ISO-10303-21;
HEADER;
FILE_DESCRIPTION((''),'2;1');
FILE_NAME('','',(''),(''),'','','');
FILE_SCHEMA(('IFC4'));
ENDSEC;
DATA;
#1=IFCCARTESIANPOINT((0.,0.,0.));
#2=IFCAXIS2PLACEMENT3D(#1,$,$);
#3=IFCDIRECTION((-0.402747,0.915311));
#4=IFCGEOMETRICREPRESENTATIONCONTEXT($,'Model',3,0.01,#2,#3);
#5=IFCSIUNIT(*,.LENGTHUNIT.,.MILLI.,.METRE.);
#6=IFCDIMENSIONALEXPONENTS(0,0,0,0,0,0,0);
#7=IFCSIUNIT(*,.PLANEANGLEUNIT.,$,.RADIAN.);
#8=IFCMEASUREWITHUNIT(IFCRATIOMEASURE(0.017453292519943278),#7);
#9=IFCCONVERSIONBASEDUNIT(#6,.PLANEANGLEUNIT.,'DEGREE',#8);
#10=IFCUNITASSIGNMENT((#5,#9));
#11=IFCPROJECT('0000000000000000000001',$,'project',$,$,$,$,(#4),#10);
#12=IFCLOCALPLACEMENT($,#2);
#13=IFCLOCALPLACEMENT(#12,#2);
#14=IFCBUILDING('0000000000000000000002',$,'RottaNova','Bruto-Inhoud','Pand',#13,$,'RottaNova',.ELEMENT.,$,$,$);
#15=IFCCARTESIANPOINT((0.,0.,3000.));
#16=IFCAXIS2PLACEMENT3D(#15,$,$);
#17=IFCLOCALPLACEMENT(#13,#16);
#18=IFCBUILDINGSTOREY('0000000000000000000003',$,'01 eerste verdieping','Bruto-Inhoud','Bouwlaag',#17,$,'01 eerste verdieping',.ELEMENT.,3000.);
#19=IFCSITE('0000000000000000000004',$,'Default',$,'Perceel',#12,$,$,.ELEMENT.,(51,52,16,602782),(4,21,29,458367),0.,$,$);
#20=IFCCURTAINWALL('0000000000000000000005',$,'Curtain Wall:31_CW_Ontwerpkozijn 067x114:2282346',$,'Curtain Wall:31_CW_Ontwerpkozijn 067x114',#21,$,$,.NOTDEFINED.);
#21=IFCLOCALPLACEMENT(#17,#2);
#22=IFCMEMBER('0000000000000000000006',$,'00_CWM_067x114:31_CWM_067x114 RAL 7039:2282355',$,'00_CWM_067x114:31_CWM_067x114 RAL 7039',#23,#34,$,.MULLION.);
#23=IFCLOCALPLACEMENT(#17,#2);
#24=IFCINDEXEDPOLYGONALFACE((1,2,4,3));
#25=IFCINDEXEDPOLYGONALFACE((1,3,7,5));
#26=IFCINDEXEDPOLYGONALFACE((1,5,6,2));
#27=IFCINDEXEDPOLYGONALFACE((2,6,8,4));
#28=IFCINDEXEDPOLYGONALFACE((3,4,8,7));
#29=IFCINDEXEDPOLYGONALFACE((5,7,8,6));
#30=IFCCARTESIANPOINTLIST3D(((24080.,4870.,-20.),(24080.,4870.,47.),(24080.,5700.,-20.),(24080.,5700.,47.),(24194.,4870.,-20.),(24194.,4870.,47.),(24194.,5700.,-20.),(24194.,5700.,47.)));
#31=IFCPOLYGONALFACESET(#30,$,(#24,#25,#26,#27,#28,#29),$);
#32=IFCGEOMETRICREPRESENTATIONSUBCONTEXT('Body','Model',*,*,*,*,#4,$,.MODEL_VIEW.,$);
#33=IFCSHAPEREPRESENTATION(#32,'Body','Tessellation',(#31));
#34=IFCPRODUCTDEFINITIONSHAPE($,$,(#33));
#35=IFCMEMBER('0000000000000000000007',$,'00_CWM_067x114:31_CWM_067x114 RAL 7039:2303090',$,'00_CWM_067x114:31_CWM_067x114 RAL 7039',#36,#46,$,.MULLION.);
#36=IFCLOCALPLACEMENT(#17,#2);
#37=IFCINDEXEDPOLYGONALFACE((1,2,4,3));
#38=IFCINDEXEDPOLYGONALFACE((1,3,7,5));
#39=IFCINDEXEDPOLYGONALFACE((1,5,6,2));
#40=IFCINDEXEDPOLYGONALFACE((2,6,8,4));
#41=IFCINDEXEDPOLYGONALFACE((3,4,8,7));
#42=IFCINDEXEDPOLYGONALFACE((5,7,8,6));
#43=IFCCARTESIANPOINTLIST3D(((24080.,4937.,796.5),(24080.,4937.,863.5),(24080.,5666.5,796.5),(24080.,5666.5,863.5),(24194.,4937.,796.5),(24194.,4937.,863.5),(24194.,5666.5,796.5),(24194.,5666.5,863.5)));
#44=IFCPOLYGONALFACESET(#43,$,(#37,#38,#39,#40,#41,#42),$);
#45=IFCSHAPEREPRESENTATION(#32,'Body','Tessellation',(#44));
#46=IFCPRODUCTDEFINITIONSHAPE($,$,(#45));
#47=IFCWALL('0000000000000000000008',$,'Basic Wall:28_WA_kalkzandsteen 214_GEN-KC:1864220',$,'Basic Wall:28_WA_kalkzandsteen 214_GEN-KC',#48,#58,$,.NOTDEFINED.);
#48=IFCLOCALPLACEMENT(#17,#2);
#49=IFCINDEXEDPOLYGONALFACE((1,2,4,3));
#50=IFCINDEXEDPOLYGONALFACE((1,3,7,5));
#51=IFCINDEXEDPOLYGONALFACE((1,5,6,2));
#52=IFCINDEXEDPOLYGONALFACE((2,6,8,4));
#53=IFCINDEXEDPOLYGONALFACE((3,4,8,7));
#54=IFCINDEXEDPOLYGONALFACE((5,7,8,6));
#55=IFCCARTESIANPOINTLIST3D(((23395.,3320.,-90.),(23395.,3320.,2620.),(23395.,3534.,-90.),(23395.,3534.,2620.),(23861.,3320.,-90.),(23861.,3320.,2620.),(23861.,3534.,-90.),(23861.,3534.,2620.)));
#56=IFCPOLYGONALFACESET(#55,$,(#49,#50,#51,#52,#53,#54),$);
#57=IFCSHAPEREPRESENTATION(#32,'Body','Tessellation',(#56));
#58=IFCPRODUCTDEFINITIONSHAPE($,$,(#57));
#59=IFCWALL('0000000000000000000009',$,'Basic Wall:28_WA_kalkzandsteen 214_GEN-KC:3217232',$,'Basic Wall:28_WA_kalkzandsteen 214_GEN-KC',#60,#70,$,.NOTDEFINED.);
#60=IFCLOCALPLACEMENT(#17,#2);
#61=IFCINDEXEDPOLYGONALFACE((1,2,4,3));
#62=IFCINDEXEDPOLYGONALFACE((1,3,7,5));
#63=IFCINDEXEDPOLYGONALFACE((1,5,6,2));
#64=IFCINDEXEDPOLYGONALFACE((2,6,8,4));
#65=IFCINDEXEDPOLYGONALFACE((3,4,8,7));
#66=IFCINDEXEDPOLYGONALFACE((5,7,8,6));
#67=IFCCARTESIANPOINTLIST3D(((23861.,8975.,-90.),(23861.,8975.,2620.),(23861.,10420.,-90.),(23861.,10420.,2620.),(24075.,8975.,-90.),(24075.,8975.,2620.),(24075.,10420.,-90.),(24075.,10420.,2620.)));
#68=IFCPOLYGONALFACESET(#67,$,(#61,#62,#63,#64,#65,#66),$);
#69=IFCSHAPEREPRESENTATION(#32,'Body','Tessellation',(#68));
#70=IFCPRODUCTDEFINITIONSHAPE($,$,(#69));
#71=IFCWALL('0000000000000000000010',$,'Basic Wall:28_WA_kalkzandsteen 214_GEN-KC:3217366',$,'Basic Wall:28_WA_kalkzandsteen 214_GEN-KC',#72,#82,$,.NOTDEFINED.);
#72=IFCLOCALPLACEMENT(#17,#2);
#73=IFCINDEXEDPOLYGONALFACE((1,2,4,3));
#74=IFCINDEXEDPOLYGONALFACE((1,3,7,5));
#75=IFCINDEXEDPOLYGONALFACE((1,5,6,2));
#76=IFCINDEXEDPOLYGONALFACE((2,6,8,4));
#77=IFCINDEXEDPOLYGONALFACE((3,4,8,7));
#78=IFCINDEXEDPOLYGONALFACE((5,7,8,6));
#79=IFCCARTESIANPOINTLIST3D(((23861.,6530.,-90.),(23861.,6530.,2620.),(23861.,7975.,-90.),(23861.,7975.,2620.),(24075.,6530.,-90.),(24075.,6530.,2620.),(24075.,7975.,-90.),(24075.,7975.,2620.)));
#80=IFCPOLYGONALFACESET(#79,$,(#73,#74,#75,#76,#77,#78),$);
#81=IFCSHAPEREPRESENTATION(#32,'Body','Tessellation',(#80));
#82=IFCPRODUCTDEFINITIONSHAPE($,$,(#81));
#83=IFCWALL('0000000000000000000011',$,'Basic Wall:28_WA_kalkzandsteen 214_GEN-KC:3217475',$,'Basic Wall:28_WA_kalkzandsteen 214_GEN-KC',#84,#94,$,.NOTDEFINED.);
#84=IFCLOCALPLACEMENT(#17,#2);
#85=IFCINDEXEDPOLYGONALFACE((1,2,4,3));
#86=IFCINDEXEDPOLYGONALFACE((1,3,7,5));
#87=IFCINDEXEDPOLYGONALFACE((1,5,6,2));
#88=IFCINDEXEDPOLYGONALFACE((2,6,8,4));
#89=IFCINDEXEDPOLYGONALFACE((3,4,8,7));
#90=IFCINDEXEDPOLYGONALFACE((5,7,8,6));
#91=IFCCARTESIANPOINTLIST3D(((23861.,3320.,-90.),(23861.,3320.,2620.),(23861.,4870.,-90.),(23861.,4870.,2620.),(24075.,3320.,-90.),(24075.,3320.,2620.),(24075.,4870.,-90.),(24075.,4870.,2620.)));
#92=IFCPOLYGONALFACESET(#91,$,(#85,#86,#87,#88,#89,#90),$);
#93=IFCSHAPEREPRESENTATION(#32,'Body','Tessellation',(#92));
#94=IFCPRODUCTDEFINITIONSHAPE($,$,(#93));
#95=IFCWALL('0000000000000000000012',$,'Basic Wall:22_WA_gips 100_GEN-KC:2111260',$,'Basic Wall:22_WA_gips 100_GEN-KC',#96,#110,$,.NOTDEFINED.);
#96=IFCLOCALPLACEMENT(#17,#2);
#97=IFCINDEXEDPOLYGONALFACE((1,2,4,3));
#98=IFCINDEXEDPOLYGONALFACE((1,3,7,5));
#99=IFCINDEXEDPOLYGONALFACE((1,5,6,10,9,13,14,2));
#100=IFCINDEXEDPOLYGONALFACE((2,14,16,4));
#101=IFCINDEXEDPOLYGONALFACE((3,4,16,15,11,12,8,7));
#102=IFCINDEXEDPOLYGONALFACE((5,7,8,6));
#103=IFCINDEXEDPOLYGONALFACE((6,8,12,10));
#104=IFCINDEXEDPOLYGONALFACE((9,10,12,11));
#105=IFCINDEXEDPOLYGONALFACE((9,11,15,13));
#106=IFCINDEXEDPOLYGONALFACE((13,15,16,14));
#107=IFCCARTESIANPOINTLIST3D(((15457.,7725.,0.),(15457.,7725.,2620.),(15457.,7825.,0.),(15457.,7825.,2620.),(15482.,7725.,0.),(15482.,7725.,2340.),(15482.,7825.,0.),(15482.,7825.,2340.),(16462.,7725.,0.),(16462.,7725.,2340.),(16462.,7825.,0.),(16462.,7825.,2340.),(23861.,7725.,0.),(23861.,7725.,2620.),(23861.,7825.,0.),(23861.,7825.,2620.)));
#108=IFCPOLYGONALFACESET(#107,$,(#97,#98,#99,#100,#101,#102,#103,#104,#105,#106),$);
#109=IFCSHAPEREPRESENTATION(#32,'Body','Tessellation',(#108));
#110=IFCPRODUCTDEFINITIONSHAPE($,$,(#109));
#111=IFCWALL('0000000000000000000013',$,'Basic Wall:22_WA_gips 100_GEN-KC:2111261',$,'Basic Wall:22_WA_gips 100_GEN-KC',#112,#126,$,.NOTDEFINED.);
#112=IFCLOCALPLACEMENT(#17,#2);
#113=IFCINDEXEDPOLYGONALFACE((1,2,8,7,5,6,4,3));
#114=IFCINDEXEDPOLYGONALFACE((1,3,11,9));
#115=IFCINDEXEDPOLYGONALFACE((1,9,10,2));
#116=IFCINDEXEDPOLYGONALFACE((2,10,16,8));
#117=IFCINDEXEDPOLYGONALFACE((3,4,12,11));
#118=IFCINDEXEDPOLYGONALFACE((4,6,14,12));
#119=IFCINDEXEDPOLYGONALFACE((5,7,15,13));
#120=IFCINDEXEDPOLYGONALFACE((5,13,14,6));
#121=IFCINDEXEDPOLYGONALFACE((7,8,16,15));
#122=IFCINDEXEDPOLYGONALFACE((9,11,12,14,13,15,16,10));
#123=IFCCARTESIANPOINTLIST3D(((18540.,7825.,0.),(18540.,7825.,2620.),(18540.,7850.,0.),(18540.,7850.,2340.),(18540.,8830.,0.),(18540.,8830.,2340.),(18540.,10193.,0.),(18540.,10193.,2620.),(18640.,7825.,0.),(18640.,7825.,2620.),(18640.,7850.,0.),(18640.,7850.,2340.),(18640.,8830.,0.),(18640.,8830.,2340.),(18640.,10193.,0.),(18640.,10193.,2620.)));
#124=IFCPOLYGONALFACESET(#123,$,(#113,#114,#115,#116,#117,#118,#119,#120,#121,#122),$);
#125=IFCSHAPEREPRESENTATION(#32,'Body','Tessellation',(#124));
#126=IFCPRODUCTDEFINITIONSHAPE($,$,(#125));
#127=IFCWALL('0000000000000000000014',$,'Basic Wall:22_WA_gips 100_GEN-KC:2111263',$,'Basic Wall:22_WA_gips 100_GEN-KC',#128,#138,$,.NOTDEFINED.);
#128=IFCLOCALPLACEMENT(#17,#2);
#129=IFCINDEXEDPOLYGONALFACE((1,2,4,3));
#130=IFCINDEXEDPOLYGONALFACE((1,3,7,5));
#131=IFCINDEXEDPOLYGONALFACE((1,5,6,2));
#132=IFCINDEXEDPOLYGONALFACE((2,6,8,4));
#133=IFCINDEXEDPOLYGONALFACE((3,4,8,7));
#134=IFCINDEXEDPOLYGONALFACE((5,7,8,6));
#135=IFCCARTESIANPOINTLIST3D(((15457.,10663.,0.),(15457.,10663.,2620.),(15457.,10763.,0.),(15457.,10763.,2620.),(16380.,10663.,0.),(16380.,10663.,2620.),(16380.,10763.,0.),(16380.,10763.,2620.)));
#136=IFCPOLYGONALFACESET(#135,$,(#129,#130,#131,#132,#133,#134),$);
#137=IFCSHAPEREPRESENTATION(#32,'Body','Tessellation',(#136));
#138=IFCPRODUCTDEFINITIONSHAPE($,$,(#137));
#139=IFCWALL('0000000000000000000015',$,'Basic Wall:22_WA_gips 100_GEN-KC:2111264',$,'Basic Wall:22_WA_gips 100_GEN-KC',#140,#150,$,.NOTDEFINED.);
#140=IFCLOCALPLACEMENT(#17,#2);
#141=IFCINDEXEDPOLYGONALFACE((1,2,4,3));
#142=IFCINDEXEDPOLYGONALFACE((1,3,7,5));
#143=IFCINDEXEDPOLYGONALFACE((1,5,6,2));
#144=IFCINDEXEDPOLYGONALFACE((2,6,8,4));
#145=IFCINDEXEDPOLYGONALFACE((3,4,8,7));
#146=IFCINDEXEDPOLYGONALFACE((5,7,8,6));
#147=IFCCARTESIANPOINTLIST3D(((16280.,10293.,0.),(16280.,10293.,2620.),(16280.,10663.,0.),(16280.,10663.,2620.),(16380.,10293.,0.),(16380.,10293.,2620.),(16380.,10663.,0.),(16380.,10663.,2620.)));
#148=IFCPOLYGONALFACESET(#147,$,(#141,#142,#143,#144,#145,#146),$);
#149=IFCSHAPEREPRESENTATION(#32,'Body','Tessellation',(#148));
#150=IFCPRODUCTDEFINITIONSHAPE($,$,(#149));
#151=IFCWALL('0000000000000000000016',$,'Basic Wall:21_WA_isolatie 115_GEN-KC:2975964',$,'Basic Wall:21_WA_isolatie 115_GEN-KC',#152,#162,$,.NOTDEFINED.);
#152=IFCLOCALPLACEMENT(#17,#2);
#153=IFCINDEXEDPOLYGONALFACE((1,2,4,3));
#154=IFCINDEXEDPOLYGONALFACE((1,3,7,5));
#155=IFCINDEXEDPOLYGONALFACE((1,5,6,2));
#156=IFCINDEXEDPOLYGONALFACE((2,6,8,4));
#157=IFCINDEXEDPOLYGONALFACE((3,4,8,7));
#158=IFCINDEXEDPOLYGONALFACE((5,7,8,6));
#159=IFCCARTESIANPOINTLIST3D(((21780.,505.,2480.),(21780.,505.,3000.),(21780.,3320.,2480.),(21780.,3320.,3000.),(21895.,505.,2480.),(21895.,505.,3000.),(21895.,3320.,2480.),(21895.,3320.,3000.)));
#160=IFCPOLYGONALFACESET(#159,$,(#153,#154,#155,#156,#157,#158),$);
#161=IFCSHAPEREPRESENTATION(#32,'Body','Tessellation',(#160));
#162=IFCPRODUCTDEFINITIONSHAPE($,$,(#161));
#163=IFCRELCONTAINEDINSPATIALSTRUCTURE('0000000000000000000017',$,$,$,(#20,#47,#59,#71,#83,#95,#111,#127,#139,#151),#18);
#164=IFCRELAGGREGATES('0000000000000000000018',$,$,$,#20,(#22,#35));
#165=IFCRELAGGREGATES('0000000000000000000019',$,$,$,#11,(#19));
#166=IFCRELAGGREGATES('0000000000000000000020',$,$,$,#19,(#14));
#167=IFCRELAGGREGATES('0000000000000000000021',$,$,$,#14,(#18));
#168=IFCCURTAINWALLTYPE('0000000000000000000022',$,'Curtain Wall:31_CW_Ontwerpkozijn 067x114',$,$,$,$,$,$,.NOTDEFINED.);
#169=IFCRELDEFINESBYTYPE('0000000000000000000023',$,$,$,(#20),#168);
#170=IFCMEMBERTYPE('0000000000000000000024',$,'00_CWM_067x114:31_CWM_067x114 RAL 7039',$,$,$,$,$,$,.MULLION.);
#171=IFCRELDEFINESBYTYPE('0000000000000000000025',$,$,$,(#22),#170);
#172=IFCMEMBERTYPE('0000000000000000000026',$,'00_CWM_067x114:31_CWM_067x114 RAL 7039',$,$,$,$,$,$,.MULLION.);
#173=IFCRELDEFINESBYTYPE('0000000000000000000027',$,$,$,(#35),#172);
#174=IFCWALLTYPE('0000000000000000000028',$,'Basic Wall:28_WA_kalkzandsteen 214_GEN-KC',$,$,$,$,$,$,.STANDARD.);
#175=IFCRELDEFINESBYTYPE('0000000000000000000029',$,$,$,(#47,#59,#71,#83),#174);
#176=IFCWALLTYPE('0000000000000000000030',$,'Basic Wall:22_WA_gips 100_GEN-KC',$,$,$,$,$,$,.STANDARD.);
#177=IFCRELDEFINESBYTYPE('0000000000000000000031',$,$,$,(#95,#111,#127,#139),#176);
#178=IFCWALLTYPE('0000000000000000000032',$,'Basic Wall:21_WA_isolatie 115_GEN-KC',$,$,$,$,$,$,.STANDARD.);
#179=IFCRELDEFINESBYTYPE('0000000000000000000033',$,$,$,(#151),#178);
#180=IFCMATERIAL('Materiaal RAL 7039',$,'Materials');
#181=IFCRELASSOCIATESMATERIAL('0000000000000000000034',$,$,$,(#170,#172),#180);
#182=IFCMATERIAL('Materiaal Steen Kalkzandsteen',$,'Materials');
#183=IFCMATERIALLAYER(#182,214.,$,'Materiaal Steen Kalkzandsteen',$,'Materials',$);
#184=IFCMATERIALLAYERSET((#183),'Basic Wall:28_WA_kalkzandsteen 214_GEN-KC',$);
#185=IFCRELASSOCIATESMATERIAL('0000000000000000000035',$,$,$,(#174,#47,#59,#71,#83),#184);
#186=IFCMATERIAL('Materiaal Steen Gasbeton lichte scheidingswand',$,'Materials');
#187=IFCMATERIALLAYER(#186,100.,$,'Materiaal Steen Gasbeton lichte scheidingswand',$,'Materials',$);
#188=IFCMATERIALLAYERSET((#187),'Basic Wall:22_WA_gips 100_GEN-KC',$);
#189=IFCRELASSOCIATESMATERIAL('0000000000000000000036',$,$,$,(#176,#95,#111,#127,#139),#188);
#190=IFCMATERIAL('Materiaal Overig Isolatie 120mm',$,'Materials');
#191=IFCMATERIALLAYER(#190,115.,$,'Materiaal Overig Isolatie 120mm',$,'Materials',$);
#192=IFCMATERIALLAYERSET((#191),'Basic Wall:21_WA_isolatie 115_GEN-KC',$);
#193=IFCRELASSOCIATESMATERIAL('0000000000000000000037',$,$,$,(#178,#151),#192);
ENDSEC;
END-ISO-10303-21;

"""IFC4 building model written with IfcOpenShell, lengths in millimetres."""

from ifc_helpers import new_model, entity, si_unit, converted_unit, direction, frame, frame_2d, origin, origin_2d_with_axis, place, context, subcontext, project, spatial, rectangle, extrude, source, transform, mapped, material, layer, layer_set, material_profile, profile_set, type_object, type_shapes, element, aggregate, save


model = new_model("IFC4")

# Units and contexts
model_context = context("Model", 3, precision=0.01, world=origin(), true_north=direction((-0.402747, 0.915311)))
body_context = subcontext(model_context, "Body", "Model", "MODEL_VIEW")
ifc_project = project(units=[si_unit("LENGTHUNIT", "METRE", prefix="MILLI"), converted_unit("PLANEANGLEUNIT", "DEGREE", entity("IfcRatioMeasure", 0.017453292519943278), si_unit("PLANEANGLEUNIT", "RADIAN"), dimensions=[0, 0, 0, 0, 0, 0, 0])], contexts=[model_context])

# Site, building, storey
site_placement = place(None, origin())
site = spatial("IfcSite", under=ifc_project, at=site_placement, Name="Default", ObjectType="Perceel", CompositionType="ELEMENT", RefLatitude=(51, 52, 16, 602782), RefLongitude=(4, 21, 29, 458367), RefElevation=0.0)
building_placement = place(site_placement, origin())
building = spatial("IfcBuilding", under=site, at=building_placement, Name="RottaNova", Description="Bruto-Inhoud", ObjectType="Pand", LongName="RottaNova", CompositionType="ELEMENT")
storey_placement = place(building_placement, frame((0.0, 0.0, 3000.0)))
storey = spatial("IfcBuildingStorey", under=building, at=storey_placement, Name="01 eerste verdieping", Description="Bruto-Inhoud", ObjectType="Bouwlaag", LongName="01 eerste verdieping", CompositionType="ELEMENT", Elevation=3000.0)

# Curtain wall, members
curtain_wall_type = type_object("IfcCurtainWallType", Name="Curtain Wall:31_CW_Ontwerpkozijn 067x114", PredefinedType="NOTDEFINED")
ifc_material_1 = material(Name="Materiaal RAL 7039", Category="Materials")
ifc_material_profile = material_profile(ifc_material_1, rectangle(XDim=114.0, YDim=67.0, at=origin_2d_with_axis()), Name="31_CWM_067x114 RAL 7039")
ifc_profile_set = profile_set([ifc_material_profile], Name="31_CWM_067x114 RAL 7039")
curtain_wall_1_placement = place(storey_placement, frame((0.0, 0.0, -3000.0)))
curtain_wall_1 = element("IfcCurtainWall", 1, at=curtain_wall_1_placement, inside=storey, type_object=curtain_wall_type, Name="Curtain Wall:31_CW_Ontwerpkozijn 067x114:2282346", ObjectType="Curtain Wall:31_CW_Ontwerpkozijn 067x114", PredefinedType="NOTDEFINED")
member_type_1 = type_object("IfcMemberType", Name="00_CWM_067x114:31_CWM_067x114 RAL 7039", PredefinedType="MULLION", material=ifc_profile_set)
shared_shape_1 = source(origin(), body_context, "Body", "SweptSolid", [
    extrude(rectangle(XDim=114.0, YDim=67.0, at=frame_2d((0.0, 0.0), x_axis=(1.0, 0.0))), frame((-33.5, -57.0, -830.0), z_axis=(0.0, 0.0, 1.0), x_axis=(0.0, -1.0, 0.0)), (0.0, 0.0, 1.0), 830.0),
])
type_shapes(member_type_1, [shared_shape_1])
member_1_placement = place(curtain_wall_1_placement, frame((24080.0, 5700.0, 2980.0), z_axis=(0.0, 1.0, 0.0), x_axis=(0.0, 0.0, -1.0)))
member_1 = element("IfcMember", 2, at=member_1_placement, type_object=member_type_1, Name="00_CWM_067x114:31_CWM_067x114 RAL 7039:2282355", ObjectType="00_CWM_067x114:31_CWM_067x114 RAL 7039", PredefinedType="MULLION", context=body_context, shape_type="MappedRepresentation", body=[
    mapped(shared_shape_1, transform((0.0, 0.0, 0.0), scale=1.0)),
])
member_type_2 = type_object("IfcMemberType", Name="00_CWM_067x114:31_CWM_067x114 RAL 7039", PredefinedType="MULLION", material=ifc_profile_set)
shared_shape_2 = source(origin(), body_context, "Body", "SweptSolid", [
    extrude(rectangle(XDim=114.0, YDim=67.0, at=origin_2d_with_axis()), frame((0.0, -57.0, -729.5), z_axis=(0.0, 0.0, 1.0), x_axis=(0.0, -1.0, 0.0)), (0.0, 0.0, 1.0), 729.5),
])
type_shapes(member_type_2, [shared_shape_2])
member_2_placement = place(curtain_wall_1_placement, frame((24080.0, 4937.0, 3830.0), z_axis=(0.0, -1.0, 0.0), x_axis=(0.0, 0.0, 1.0)))
member_2 = element("IfcMember", 3, at=member_2_placement, type_object=member_type_2, Name="00_CWM_067x114:31_CWM_067x114 RAL 7039:2303090", ObjectType="00_CWM_067x114:31_CWM_067x114 RAL 7039", PredefinedType="MULLION", context=body_context, shape_type="MappedRepresentation", body=[
    mapped(shared_shape_2, transform((0.0, 0.0, 0.0), scale=1.0)),
])

# Walls
ifc_material_2 = material(Name="Materiaal Steen Kalkzandsteen", Category="Materials")
ifc_layer_1 = layer(ifc_material_2, 214.0, Name="Materiaal Steen Kalkzandsteen", Category="Materials")
ifc_layer_set_1 = layer_set([ifc_layer_1], Name="Basic Wall:28_WA_kalkzandsteen 214_GEN-KC")
wall_type_1 = type_object("IfcWallType", Name="Basic Wall:28_WA_kalkzandsteen 214_GEN-KC", PredefinedType="STANDARD", material=ifc_layer_set_1)
wall_1_placement = place(storey_placement, frame((23861.0, 3427.0, -90.0), z_axis=(0.0, 0.0, 1.0), x_axis=(-1.0, 0.0, 0.0)))
element("IfcWall", 4, at=wall_1_placement, inside=storey, type_object=wall_type_1, material=ifc_layer_set_1, Name="Basic Wall:28_WA_kalkzandsteen 214_GEN-KC:1864220", ObjectType="Basic Wall:28_WA_kalkzandsteen 214_GEN-KC", PredefinedType="NOTDEFINED", context=body_context, shape_type="SweptSolid", body=[
    extrude(rectangle(XDim=466.0, YDim=214.0, at=frame_2d((233.0, 0.0), x_axis=(-1.0, 0.0))), origin(), (0.0, 0.0, 1.0), 2710.0),
])
wall_2_placement = place(storey_placement, frame((23968.0, 10420.0, -90.0), z_axis=(0.0, 0.0, 1.0), x_axis=(0.0, -1.0, 0.0)))
element("IfcWall", 5, at=wall_2_placement, inside=storey, type_object=wall_type_1, material=ifc_layer_set_1, Name="Basic Wall:28_WA_kalkzandsteen 214_GEN-KC:3217232", ObjectType="Basic Wall:28_WA_kalkzandsteen 214_GEN-KC", PredefinedType="NOTDEFINED", context=body_context, shape_type="SweptSolid", body=[
    extrude(rectangle(XDim=1445.0, YDim=214.0, at=frame_2d((722.5, 0.0), x_axis=(-1.0, 0.0))), origin(), (0.0, 0.0, 1.0), 2710.0),
])
wall_3_placement = place(storey_placement, frame((23968.0, 7975.0, -90.0), z_axis=(0.0, 0.0, 1.0), x_axis=(0.0, -1.0, 0.0)))
element("IfcWall", 6, at=wall_3_placement, inside=storey, type_object=wall_type_1, material=ifc_layer_set_1, Name="Basic Wall:28_WA_kalkzandsteen 214_GEN-KC:3217366", ObjectType="Basic Wall:28_WA_kalkzandsteen 214_GEN-KC", PredefinedType="NOTDEFINED", context=body_context, shape_type="SweptSolid", body=[
    extrude(rectangle(XDim=1445.0, YDim=214.0, at=frame_2d((722.5, 0.0), x_axis=(-1.0, 0.0))), origin(), (0.0, 0.0, 1.0), 2710.0),
])
wall_4_placement = place(storey_placement, frame((23968.0, 4870.0, -90.0), z_axis=(0.0, 0.0, 1.0), x_axis=(0.0, -1.0, 0.0)))
element("IfcWall", 7, at=wall_4_placement, inside=storey, type_object=wall_type_1, material=ifc_layer_set_1, Name="Basic Wall:28_WA_kalkzandsteen 214_GEN-KC:3217475", ObjectType="Basic Wall:28_WA_kalkzandsteen 214_GEN-KC", PredefinedType="NOTDEFINED", context=body_context, shape_type="SweptSolid", body=[
    extrude(rectangle(XDim=1550.0, YDim=214.0, at=frame_2d((775.0, 0.0), x_axis=(-1.0, 0.0))), origin(), (0.0, 0.0, 1.0), 2710.0),
])

# Walls, openings
ifc_material_3 = material(Name="Materiaal Steen Gasbeton lichte scheidingswand", Category="Materials")
ifc_layer_2 = layer(ifc_material_3, 100.0, Name="Materiaal Steen Gasbeton lichte scheidingswand", Category="Materials")
ifc_layer_set_2 = layer_set([ifc_layer_2], Name="Basic Wall:22_WA_gips 100_GEN-KC")
wall_type_2 = type_object("IfcWallType", Name="Basic Wall:22_WA_gips 100_GEN-KC", PredefinedType="STANDARD", material=ifc_layer_set_2)
wall_5_placement = place(storey_placement, frame((23861.0, 7775.0, 0.0), z_axis=(0.0, 0.0, 1.0), x_axis=(-1.0, 0.0, 0.0)))
wall_5 = element("IfcWall", 8, at=wall_5_placement, inside=storey, type_object=wall_type_2, material=ifc_layer_set_2, Name="Basic Wall:22_WA_gips 100_GEN-KC:2111260", ObjectType="Basic Wall:22_WA_gips 100_GEN-KC", PredefinedType="NOTDEFINED", context=body_context, shape_type="SweptSolid", body=[
    extrude(rectangle(XDim=8404.0, YDim=100.0, at=frame_2d((4202.0, 0.0), x_axis=(1.0, 0.0))), origin(), (0.0, 0.0, 1.0), 2620.0),
])
opening_1_placement = place(wall_5_placement, frame((7399.0, -50.0, -90.0)))
element("IfcOpeningElement", 9, at=opening_1_placement, cuts=wall_5, PredefinedType="OPENING", context=body_context, shape_type="SweptSolid", body=[
    extrude(rectangle(XDim=2430.0, YDim=980.0, at=frame_2d((1215.0, 490.0), x_axis=(1.0, 0.0))), frame((0.0, 0.0, 0.0), z_axis=(0.0, 1.0, 0.0), x_axis=(0.0, 0.0, 1.0)), (0.0, 0.0, 1.0), 100.0),
])
wall_6_placement = place(storey_placement, frame((18590.0, 10193.0, 0.0), z_axis=(0.0, 0.0, 1.0), x_axis=(0.0, -1.0, 0.0)))
wall_6 = element("IfcWall", 10, at=wall_6_placement, inside=storey, type_object=wall_type_2, material=ifc_layer_set_2, Name="Basic Wall:22_WA_gips 100_GEN-KC:2111261", ObjectType="Basic Wall:22_WA_gips 100_GEN-KC", PredefinedType="NOTDEFINED", context=body_context, shape_type="SweptSolid", body=[
    extrude(rectangle(XDim=2368.0, YDim=100.0, at=frame_2d((1184.0, 0.0), x_axis=(1.0, 0.0))), origin(), (0.0, 0.0, 1.0), 2620.0),
])
opening_2_placement = place(wall_6_placement, frame((1363.0, -50.0, -90.0)))
element("IfcOpeningElement", 11, at=opening_2_placement, cuts=wall_6, PredefinedType="OPENING", context=body_context, shape_type="SweptSolid", body=[
    extrude(rectangle(XDim=2430.0, YDim=980.0, at=frame_2d((1215.0, 490.0), x_axis=(1.0, 0.0))), frame((0.0, 0.0, 0.0), z_axis=(0.0, 1.0, 0.0), x_axis=(0.0, 0.0, 1.0)), (0.0, 0.0, 1.0), 100.0),
])

# Walls
wall_7_placement = place(storey_placement, frame((16380.0, 10713.0, 0.0), z_axis=(0.0, 0.0, 1.0), x_axis=(-1.0, 0.0, 0.0)))
element("IfcWall", 12, at=wall_7_placement, inside=storey, type_object=wall_type_2, material=ifc_layer_set_2, Name="Basic Wall:22_WA_gips 100_GEN-KC:2111263", ObjectType="Basic Wall:22_WA_gips 100_GEN-KC", PredefinedType="NOTDEFINED", context=body_context, shape_type="SweptSolid", body=[
    extrude(rectangle(XDim=923.0, YDim=100.0, at=frame_2d((461.5, 0.0), x_axis=(-1.0, 0.0))), origin(), (0.0, 0.0, 1.0), 2620.0),
])
wall_8_placement = place(storey_placement, frame((16330.0, 10663.0, 0.0), z_axis=(0.0, 0.0, 1.0), x_axis=(0.0, -1.0, 0.0)))
element("IfcWall", 13, at=wall_8_placement, inside=storey, type_object=wall_type_2, material=ifc_layer_set_2, Name="Basic Wall:22_WA_gips 100_GEN-KC:2111264", ObjectType="Basic Wall:22_WA_gips 100_GEN-KC", PredefinedType="NOTDEFINED", context=body_context, shape_type="SweptSolid", body=[
    extrude(rectangle(XDim=370.0, YDim=100.0, at=frame_2d((185.0, 0.0), x_axis=(-1.0, 0.0))), origin(), (0.0, 0.0, 1.0), 2620.0),
])
ifc_material_4 = material(Name="Materiaal Overig Isolatie 120mm", Category="Materials")
ifc_layer_3 = layer(ifc_material_4, 115.0, Name="Materiaal Overig Isolatie 120mm", Category="Materials")
ifc_layer_set_3 = layer_set([ifc_layer_3], Name="Basic Wall:21_WA_isolatie 115_GEN-KC")
wall_type_3 = type_object("IfcWallType", Name="Basic Wall:21_WA_isolatie 115_GEN-KC", PredefinedType="STANDARD", material=ifc_layer_set_3)
wall_9_placement = place(storey_placement, frame((21837.5, 3320.0, 2480.0), z_axis=(0.0, 0.0, 1.0), x_axis=(0.0, -1.0, 0.0)))
element("IfcWall", 14, at=wall_9_placement, inside=storey, type_object=wall_type_3, material=ifc_layer_set_3, Name="Basic Wall:21_WA_isolatie 115_GEN-KC:2975964", ObjectType="Basic Wall:21_WA_isolatie 115_GEN-KC", PredefinedType="NOTDEFINED", context=body_context, shape_type="SweptSolid", body=[
    extrude(rectangle(XDim=2815.0, YDim=115.0, at=frame_2d((1407.5, 0.0), x_axis=(-1.0, 0.0))), origin(), (0.0, 0.0, 1.0), 520.0),
])

aggregate(curtain_wall_1, [member_1, member_2])

save(model, "model.ifc")
